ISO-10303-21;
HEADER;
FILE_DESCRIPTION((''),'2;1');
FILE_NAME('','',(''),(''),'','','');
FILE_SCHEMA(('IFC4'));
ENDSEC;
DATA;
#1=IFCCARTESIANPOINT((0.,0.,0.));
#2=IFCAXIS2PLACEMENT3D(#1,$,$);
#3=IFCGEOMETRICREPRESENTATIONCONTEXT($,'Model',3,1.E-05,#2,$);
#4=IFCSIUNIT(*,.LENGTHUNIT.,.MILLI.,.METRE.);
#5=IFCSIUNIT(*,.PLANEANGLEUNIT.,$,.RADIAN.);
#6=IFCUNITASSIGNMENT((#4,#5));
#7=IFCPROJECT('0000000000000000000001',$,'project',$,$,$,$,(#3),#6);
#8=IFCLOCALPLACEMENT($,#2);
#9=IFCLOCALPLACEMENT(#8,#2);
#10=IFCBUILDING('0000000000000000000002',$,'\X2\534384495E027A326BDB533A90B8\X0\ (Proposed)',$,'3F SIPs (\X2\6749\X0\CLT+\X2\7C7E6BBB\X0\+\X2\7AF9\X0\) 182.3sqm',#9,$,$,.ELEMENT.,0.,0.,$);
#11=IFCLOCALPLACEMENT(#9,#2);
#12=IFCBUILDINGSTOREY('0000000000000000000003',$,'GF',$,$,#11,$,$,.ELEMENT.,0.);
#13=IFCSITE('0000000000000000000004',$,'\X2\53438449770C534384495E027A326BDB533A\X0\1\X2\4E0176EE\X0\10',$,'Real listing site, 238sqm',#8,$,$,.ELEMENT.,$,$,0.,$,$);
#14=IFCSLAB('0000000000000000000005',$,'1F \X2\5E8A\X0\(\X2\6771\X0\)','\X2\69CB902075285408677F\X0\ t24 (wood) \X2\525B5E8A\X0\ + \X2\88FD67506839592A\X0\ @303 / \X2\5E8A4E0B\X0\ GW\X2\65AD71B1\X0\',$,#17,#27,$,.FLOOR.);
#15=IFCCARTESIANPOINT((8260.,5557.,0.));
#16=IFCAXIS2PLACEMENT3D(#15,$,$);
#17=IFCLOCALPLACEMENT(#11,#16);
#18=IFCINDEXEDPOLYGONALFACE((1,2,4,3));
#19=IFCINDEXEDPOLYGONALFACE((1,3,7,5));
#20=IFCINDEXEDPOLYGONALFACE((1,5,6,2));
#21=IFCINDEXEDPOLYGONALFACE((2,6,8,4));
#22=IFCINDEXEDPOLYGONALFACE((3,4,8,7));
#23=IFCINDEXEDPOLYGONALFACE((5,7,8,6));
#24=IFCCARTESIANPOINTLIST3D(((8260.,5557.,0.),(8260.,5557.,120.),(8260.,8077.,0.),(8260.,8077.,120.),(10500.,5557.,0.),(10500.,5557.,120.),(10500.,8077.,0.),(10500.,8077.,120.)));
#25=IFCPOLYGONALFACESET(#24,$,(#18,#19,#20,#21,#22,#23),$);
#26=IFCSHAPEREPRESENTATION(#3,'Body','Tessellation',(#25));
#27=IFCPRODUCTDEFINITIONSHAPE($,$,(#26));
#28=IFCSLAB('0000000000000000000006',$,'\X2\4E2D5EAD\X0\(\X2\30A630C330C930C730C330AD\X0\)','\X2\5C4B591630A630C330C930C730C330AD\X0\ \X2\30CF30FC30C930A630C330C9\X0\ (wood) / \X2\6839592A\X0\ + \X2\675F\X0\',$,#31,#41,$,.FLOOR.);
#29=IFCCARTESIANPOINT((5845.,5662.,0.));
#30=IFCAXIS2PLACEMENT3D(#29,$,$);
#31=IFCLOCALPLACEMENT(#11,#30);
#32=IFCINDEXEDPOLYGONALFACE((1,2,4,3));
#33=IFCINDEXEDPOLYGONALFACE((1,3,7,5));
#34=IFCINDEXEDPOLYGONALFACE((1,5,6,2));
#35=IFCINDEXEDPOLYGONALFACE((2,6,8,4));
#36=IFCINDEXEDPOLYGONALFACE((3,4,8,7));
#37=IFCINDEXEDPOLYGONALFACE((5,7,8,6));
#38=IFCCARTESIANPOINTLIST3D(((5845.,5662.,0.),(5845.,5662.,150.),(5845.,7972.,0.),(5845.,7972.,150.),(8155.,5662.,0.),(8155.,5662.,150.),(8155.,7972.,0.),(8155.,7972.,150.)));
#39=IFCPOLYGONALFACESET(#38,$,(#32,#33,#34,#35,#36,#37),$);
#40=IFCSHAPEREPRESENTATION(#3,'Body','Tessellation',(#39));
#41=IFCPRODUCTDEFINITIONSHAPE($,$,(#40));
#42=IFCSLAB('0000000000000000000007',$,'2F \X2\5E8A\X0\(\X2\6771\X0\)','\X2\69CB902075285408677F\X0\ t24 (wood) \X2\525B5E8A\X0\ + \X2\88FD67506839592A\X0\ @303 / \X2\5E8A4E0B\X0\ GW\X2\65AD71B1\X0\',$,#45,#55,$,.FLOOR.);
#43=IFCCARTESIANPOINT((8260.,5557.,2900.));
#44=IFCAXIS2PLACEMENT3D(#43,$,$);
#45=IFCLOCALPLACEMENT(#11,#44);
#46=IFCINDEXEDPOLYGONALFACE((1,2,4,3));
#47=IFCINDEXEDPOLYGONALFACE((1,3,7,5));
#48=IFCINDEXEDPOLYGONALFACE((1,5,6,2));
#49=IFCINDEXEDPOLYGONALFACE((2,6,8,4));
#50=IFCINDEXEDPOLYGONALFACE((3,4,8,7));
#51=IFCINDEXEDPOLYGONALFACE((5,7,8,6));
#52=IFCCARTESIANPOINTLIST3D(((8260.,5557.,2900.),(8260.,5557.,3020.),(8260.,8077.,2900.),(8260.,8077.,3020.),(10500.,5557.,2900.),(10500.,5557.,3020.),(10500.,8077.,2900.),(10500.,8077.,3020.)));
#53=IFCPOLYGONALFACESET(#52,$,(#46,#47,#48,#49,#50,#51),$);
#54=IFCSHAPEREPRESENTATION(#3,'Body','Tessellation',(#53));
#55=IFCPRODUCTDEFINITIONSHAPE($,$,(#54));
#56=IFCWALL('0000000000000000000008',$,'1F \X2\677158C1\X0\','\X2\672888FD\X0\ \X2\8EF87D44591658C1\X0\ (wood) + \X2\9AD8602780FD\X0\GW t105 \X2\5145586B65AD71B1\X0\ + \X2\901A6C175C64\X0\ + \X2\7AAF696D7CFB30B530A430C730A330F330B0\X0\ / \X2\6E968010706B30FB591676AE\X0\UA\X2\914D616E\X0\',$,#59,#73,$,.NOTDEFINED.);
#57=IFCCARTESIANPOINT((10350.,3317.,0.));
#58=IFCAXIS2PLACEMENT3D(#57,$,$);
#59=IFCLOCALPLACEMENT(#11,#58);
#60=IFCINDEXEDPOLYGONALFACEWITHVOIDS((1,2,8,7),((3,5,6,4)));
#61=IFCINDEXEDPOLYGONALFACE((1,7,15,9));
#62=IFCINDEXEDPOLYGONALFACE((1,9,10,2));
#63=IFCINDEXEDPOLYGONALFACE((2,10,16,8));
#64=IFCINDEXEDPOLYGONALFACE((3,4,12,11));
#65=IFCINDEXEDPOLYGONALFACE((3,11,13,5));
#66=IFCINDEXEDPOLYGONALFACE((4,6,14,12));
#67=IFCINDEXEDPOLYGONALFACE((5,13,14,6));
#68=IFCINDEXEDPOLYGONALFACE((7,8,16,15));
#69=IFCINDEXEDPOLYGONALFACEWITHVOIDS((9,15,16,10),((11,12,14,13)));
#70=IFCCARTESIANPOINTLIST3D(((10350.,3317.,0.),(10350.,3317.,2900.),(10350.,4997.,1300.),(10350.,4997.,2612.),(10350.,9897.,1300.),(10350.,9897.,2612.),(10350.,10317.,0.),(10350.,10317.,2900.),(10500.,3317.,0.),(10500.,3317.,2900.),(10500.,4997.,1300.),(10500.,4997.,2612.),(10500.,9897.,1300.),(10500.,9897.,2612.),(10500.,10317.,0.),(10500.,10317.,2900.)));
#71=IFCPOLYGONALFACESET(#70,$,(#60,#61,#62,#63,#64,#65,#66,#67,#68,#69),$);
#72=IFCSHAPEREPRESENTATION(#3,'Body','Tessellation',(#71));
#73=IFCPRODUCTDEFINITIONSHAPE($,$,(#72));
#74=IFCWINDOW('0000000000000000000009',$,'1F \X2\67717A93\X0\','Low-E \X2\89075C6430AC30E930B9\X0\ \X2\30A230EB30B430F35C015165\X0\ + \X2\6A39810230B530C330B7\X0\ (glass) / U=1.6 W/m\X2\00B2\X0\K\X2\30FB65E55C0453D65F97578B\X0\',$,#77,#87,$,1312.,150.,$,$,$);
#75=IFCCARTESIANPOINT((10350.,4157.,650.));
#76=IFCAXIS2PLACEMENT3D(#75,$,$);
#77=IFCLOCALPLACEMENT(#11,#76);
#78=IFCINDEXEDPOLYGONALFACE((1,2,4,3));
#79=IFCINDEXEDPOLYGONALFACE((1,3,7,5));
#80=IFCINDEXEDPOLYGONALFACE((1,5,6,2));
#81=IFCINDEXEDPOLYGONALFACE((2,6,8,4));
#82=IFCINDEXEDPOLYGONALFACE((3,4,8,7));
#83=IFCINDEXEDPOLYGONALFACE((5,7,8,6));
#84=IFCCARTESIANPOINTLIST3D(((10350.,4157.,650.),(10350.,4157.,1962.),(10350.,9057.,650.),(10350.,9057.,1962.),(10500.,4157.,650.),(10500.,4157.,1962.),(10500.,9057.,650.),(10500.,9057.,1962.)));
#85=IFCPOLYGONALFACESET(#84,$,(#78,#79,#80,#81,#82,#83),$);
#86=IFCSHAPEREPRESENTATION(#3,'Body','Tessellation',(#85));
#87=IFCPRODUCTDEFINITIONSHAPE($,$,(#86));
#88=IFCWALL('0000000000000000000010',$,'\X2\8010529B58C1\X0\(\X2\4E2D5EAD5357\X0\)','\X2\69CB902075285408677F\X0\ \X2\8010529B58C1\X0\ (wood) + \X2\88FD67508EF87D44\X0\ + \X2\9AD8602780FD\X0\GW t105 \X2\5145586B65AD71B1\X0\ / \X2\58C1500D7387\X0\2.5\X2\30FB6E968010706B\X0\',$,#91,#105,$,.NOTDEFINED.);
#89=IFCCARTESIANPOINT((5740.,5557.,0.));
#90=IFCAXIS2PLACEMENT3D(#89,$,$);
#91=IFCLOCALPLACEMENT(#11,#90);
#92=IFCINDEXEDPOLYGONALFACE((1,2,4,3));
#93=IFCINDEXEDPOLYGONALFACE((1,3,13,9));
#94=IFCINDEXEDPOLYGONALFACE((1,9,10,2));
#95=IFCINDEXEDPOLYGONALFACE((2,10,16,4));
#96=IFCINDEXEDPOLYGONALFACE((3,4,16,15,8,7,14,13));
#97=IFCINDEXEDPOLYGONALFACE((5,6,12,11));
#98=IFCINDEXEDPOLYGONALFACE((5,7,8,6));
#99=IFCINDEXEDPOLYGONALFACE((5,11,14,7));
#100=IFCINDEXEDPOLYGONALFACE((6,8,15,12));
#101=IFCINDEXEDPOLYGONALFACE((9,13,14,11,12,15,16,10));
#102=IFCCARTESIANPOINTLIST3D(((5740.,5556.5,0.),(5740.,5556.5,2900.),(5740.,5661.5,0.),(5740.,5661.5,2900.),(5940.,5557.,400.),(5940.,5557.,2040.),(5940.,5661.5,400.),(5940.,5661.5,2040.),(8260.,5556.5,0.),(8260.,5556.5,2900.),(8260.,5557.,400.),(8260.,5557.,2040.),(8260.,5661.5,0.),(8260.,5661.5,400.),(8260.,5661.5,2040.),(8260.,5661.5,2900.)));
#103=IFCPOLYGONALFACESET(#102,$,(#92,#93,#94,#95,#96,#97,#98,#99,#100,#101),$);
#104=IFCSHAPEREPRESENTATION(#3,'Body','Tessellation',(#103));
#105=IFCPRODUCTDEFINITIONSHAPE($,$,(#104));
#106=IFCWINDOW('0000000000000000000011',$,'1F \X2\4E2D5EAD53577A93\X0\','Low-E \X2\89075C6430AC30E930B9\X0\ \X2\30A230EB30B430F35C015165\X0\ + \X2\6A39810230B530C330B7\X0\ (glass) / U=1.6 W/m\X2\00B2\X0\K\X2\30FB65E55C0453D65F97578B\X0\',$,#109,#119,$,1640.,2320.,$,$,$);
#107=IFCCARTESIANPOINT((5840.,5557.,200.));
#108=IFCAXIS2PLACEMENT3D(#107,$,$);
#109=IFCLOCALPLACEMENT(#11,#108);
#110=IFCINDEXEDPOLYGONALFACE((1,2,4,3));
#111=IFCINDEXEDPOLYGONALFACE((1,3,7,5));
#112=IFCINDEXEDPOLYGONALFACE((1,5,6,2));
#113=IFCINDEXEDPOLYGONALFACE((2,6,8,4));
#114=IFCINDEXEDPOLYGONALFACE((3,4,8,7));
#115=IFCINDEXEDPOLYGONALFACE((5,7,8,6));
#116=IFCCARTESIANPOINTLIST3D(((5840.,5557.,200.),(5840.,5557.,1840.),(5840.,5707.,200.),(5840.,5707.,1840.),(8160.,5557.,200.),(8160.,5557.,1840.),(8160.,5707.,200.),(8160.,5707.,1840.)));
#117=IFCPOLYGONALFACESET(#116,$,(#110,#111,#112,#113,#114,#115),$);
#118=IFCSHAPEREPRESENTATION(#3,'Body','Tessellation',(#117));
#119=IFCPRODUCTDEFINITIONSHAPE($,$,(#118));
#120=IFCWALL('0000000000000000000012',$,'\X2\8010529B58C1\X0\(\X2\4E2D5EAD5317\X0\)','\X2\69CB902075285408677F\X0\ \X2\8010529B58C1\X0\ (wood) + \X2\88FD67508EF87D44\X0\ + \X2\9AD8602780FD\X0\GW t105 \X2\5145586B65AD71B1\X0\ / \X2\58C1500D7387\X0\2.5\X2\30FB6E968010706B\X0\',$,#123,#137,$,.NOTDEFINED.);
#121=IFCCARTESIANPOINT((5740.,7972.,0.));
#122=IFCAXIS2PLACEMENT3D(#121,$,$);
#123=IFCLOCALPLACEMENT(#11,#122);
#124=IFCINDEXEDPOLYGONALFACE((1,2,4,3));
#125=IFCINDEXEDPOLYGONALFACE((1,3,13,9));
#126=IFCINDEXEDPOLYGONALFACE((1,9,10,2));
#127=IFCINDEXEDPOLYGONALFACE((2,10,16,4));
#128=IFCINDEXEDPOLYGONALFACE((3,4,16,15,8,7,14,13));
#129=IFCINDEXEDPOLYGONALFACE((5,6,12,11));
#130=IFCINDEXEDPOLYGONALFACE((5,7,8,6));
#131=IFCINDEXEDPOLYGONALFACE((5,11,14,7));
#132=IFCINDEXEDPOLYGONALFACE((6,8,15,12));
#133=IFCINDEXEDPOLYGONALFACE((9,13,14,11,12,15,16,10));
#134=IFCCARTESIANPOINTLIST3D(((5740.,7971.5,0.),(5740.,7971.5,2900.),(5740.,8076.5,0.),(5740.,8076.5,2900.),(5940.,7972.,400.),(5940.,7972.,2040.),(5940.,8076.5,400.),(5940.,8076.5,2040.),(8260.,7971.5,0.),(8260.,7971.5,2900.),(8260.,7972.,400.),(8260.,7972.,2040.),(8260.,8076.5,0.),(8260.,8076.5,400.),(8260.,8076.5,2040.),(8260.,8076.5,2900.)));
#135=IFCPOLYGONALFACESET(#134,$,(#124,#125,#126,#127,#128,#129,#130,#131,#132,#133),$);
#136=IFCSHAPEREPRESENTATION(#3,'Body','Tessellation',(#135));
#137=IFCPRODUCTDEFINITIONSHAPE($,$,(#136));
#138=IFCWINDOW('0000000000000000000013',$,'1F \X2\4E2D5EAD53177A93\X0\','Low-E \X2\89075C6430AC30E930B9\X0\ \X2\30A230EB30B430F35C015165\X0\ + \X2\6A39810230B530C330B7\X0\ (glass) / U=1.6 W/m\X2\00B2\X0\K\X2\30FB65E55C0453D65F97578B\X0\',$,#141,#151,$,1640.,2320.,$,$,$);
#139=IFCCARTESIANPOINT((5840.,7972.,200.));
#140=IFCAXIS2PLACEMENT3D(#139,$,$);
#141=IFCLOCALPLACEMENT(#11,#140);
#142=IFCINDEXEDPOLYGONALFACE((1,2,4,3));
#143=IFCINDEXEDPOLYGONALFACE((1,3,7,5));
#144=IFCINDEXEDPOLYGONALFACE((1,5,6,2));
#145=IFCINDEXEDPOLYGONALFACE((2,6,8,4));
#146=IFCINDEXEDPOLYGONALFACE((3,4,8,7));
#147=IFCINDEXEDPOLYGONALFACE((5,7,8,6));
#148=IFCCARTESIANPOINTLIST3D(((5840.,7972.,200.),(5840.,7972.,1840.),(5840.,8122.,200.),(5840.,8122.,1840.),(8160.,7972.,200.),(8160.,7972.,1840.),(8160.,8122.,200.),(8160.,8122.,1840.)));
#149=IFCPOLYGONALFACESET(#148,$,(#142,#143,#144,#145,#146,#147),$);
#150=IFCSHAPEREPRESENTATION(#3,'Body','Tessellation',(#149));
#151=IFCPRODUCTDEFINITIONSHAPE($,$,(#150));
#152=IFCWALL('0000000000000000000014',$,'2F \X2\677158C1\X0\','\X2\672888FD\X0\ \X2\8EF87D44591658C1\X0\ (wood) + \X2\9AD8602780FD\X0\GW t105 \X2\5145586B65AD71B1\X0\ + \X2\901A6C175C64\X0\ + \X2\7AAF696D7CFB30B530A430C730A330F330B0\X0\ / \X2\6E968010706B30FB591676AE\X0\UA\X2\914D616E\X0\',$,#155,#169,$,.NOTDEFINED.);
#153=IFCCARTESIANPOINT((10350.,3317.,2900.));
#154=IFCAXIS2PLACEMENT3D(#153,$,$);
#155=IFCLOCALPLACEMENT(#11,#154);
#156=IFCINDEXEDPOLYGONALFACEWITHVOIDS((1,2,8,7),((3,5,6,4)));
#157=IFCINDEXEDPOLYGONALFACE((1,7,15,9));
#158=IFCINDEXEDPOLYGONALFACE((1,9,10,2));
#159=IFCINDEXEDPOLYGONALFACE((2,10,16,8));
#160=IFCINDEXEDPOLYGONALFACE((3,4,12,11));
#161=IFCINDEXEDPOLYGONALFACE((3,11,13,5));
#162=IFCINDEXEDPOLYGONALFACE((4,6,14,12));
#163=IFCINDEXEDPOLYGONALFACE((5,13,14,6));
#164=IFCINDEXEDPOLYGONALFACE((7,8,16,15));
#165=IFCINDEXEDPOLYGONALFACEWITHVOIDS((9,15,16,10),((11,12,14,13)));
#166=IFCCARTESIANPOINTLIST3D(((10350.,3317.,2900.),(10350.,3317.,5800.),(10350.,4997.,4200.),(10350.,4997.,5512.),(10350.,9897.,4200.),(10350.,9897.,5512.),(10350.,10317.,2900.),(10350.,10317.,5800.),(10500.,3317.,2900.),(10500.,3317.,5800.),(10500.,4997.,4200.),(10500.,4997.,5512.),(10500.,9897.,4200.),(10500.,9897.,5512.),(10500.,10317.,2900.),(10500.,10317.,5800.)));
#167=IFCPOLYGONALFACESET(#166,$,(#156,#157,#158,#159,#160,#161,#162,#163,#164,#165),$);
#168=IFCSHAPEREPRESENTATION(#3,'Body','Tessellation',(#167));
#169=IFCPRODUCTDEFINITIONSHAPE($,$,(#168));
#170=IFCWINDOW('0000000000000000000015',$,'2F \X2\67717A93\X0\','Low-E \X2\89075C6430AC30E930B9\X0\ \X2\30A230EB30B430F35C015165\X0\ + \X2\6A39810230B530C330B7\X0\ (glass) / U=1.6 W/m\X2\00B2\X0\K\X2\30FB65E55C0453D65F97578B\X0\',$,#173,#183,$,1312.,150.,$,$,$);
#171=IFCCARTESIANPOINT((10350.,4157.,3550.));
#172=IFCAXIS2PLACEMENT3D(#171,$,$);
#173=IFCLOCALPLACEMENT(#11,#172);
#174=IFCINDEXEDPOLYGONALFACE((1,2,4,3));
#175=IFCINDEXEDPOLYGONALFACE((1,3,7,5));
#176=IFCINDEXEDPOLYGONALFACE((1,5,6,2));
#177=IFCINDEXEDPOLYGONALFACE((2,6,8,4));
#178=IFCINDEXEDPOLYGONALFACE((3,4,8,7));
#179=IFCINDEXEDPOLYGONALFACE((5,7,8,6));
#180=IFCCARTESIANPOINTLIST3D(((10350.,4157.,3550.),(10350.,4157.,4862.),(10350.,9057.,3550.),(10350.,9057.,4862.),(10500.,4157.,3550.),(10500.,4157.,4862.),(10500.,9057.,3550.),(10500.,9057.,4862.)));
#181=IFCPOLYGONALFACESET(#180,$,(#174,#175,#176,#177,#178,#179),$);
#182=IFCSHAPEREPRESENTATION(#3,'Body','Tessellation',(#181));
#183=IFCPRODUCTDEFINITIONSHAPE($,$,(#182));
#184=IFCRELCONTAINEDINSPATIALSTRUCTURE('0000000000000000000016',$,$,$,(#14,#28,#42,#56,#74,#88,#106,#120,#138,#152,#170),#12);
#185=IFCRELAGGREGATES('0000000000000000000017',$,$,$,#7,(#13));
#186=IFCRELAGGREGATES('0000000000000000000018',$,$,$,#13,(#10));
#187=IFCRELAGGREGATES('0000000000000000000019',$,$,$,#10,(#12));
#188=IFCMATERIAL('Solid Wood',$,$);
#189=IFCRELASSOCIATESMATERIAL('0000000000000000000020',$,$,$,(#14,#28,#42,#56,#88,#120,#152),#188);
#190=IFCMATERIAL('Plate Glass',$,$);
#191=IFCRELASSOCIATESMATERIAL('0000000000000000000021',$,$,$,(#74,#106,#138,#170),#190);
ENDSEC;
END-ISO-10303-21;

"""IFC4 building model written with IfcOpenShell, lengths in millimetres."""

from ifc_helpers import new_model, si_unit, frame, frame_2d, origin, place, context, project, spatial, rectangle, extrude, material, element, fill, save


model = new_model("IFC4")

# Units and contexts
model_context = context("Model", 3, precision=1e-05, world=origin())
ifc_project = project(units=[si_unit("LENGTHUNIT", "METRE", prefix="MILLI"), si_unit("PLANEANGLEUNIT", "RADIAN")], contexts=[model_context])

# Site, building, storey
site_placement = place(None, origin())
site = spatial("IfcSite", under=ifc_project, at=site_placement, Name="千葉県千葉市稲毛区1丁目10", ObjectType="Real listing site, 238sqm", CompositionType="ELEMENT", RefElevation=0.0)
building_placement = place(site_placement, origin())
building = spatial("IfcBuilding", under=site, at=building_placement, Name="千葉市稲毛区邸 (Proposed)", ObjectType="3F SIPs (杉CLT+籾殻+竹) 182.3sqm", CompositionType="ELEMENT", ElevationOfRefHeight=0.0, ElevationOfTerrain=0.0)
storey_placement = place(building_placement, origin())
storey = spatial("IfcBuildingStorey", under=building, at=storey_placement, Name="GF", CompositionType="ELEMENT", Elevation=0.0)

# Slabs
ifc_material_1 = material(Name="Solid Wood")
slab_1_placement = place(storey_placement, frame((8260.0, 5557.0, 0.0)))
element("IfcSlab", 1, at=slab_1_placement, inside=storey, material=ifc_material_1, Name="1F 床(東)", Description="構造用合板 t24 (wood) 剛床 + 製材根太 @303 / 床下 GW断熱", PredefinedType="FLOOR", context=model_context, shape_type="SweptSolid", body=[
    extrude(rectangle(XDim=2240.0, YDim=2520.0, at=frame_2d((1120.0, 1260.0))), frame((8260.0, 5557.0, 0.0)), (0.0, 0.0, 1.0), 120.0),
])
slab_2_placement = place(storey_placement, frame((5845.0, 5662.0, 0.0)))
element("IfcSlab", 2, at=slab_2_placement, inside=storey, material=ifc_material_1, Name="中庭(ウッドデッキ)", Description="屋外ウッドデッキ ハードウッド (wood) / 根太 + 束", PredefinedType="FLOOR", context=model_context, shape_type="SweptSolid", body=[
    extrude(rectangle(XDim=2310.0, YDim=2310.0, at=frame_2d((1155.0, 1155.0))), frame((5845.0, 5662.0, 0.0)), (0.0, 0.0, 1.0), 150.0),
])
slab_3_placement = place(storey_placement, frame((8260.0, 5557.0, 2900.0)))
element("IfcSlab", 3, at=slab_3_placement, inside=storey, material=ifc_material_1, Name="2F 床(東)", Description="構造用合板 t24 (wood) 剛床 + 製材根太 @303 / 床下 GW断熱", PredefinedType="FLOOR", context=model_context, shape_type="SweptSolid", body=[
    extrude(rectangle(XDim=2240.0, YDim=2520.0, at=frame_2d((1120.0, 1260.0))), frame((8260.0, 5557.0, 2900.0)), (0.0, 0.0, 1.0), 120.0),
])

# Walls, openings, windows
wall_1_placement = place(storey_placement, frame((10350.0, 3317.0, 0.0)))
wall_1 = element("IfcWall", 4, at=wall_1_placement, inside=storey, material=ifc_material_1, Name="1F 東壁", Description="木製 軸組外壁 (wood) + 高性能GW t105 充填断熱 + 通気層 + 窯業系サイディング / 準耐火・外皮UA配慮", PredefinedType="NOTDEFINED", context=model_context, shape_type="SweptSolid", body=[
    extrude(rectangle(XDim=150.0, YDim=7000.0, at=frame_2d((75.0, 3500.0))), frame((10350.0, 3317.0, 0.0)), (0.0, 0.0, 1.0), 2900.0),
])
opening_1_placement = place(storey_placement, frame((10350.0, 4157.0, 650.0)))
opening_1 = element("IfcOpeningElement", 5, at=opening_1_placement, cuts=wall_1, PredefinedType="NOTDEFINED", context=model_context, shape_type="SweptSolid", body=[
    extrude(rectangle(XDim=150.0, YDim=4900.0, at=frame_2d((75.0, 2450.0))), frame((10350.0, 4157.0, 650.0)), (0.0, 0.0, 1.0), 1312.0),
])
ifc_material_2 = material(Name="Plate Glass")
window_1_placement = place(storey_placement, frame((10350.0, 4157.0, 650.0)))
window_1 = element("IfcWindow", 6, at=window_1_placement, inside=storey, material=ifc_material_2, Name="1F 東窓", Description="Low-E 複層ガラス アルゴン封入 + 樹脂サッシ (glass) / U=1.6 W/m²K・日射取得型", OverallHeight=1312.0, OverallWidth=150.0, context=model_context, shape_type="SweptSolid", body=[
    extrude(rectangle(XDim=150.0, YDim=4900.0, at=frame_2d((75.0, 2450.0))), frame((10350.0, 4157.0, 650.0)), (0.0, 0.0, 1.0), 1312.0),
])
fill(opening_1, window_1)
wall_2_placement = place(storey_placement, frame((5740.0, 5557.0, 0.0)))
wall_2 = element("IfcWall", 7, at=wall_2_placement, inside=storey, material=ifc_material_1, Name="耐力壁(中庭南)", Description="構造用合板 耐力壁 (wood) + 製材軸組 + 高性能GW t105 充填断熱 / 壁倍率2.5・準耐火", PredefinedType="NOTDEFINED", context=model_context, shape_type="SweptSolid", body=[
    extrude(rectangle(XDim=2520.0, YDim=105.0, at=frame_2d((1260.0, 52.0))), frame((5740.0, 5557.0, 0.0)), (0.0, 0.0, 1.0), 2900.0),
])
opening_2_placement = place(storey_placement, frame((5840.0, 5557.0, 200.0)))
opening_2 = element("IfcOpeningElement", 8, at=opening_2_placement, cuts=wall_2, PredefinedType="NOTDEFINED", context=model_context, shape_type="SweptSolid", body=[
    extrude(rectangle(XDim=2320.0, YDim=150.0, at=frame_2d((1160.0, 75.0))), frame((5840.0, 5557.0, 200.0)), (0.0, 0.0, 1.0), 1640.0),
])
window_2_placement = place(storey_placement, frame((5840.0, 5557.0, 200.0)))
window_2 = element("IfcWindow", 9, at=window_2_placement, inside=storey, material=ifc_material_2, Name="1F 中庭南窓", Description="Low-E 複層ガラス アルゴン封入 + 樹脂サッシ (glass) / U=1.6 W/m²K・日射取得型", OverallHeight=1640.0, OverallWidth=2320.0, context=model_context, shape_type="SweptSolid", body=[
    extrude(rectangle(XDim=2320.0, YDim=150.0, at=frame_2d((1160.0, 75.0))), frame((5840.0, 5557.0, 200.0)), (0.0, 0.0, 1.0), 1640.0),
])
fill(opening_2, window_2)
wall_3_placement = place(storey_placement, frame((5740.0, 7972.0, 0.0)))
wall_3 = element("IfcWall", 10, at=wall_3_placement, inside=storey, material=ifc_material_1, Name="耐力壁(中庭北)", Description="構造用合板 耐力壁 (wood) + 製材軸組 + 高性能GW t105 充填断熱 / 壁倍率2.5・準耐火", PredefinedType="NOTDEFINED", context=model_context, shape_type="SweptSolid", body=[
    extrude(rectangle(XDim=2520.0, YDim=105.0, at=frame_2d((1260.0, 52.0))), frame((5740.0, 7972.0, 0.0)), (0.0, 0.0, 1.0), 2900.0),
])
opening_3_placement = place(storey_placement, frame((5840.0, 7972.0, 200.0)))
opening_3 = element("IfcOpeningElement", 11, at=opening_3_placement, cuts=wall_3, PredefinedType="NOTDEFINED", context=model_context, shape_type="SweptSolid", body=[
    extrude(rectangle(XDim=2320.0, YDim=150.0, at=frame_2d((1160.0, 75.0))), frame((5840.0, 7972.0, 200.0)), (0.0, 0.0, 1.0), 1640.0),
])
window_3_placement = place(storey_placement, frame((5840.0, 7972.0, 200.0)))
window_3 = element("IfcWindow", 12, at=window_3_placement, inside=storey, material=ifc_material_2, Name="1F 中庭北窓", Description="Low-E 複層ガラス アルゴン封入 + 樹脂サッシ (glass) / U=1.6 W/m²K・日射取得型", OverallHeight=1640.0, OverallWidth=2320.0, context=model_context, shape_type="SweptSolid", body=[
    extrude(rectangle(XDim=2320.0, YDim=150.0, at=frame_2d((1160.0, 75.0))), frame((5840.0, 7972.0, 200.0)), (0.0, 0.0, 1.0), 1640.0),
])
fill(opening_3, window_3)

# Wall, opening, window
wall_4_placement = place(storey_placement, frame((10350.0, 3317.0, 2900.0)))
wall_4 = element("IfcWall", 13, at=wall_4_placement, inside=storey, material=ifc_material_1, Name="2F 東壁", Description="木製 軸組外壁 (wood) + 高性能GW t105 充填断熱 + 通気層 + 窯業系サイディング / 準耐火・外皮UA配慮", PredefinedType="NOTDEFINED", context=model_context, shape_type="SweptSolid", body=[
    extrude(rectangle(XDim=150.0, YDim=7000.0, at=frame_2d((75.0, 3500.0))), frame((10350.0, 3317.0, 2900.0)), (0.0, 0.0, 1.0), 2900.0),
])
opening_4_placement = place(storey_placement, frame((10350.0, 4157.0, 3550.0)))
opening_4 = element("IfcOpeningElement", 14, at=opening_4_placement, cuts=wall_4, PredefinedType="NOTDEFINED", context=model_context, shape_type="SweptSolid", body=[
    extrude(rectangle(XDim=150.0, YDim=4900.0, at=frame_2d((75.0, 2450.0))), frame((10350.0, 4157.0, 3550.0)), (0.0, 0.0, 1.0), 1312.0),
])
window_4_placement = place(storey_placement, frame((10350.0, 4157.0, 3550.0)))
window_4 = element("IfcWindow", 15, at=window_4_placement, inside=storey, material=ifc_material_2, Name="2F 東窓", Description="Low-E 複層ガラス アルゴン封入 + 樹脂サッシ (glass) / U=1.6 W/m²K・日射取得型", OverallHeight=1312.0, OverallWidth=150.0, context=model_context, shape_type="SweptSolid", body=[
    extrude(rectangle(XDim=150.0, YDim=4900.0, at=frame_2d((75.0, 2450.0))), frame((10350.0, 4157.0, 3550.0)), (0.0, 0.0, 1.0), 1312.0),
])
fill(opening_4, window_4)

save(model, "model.ifc")
